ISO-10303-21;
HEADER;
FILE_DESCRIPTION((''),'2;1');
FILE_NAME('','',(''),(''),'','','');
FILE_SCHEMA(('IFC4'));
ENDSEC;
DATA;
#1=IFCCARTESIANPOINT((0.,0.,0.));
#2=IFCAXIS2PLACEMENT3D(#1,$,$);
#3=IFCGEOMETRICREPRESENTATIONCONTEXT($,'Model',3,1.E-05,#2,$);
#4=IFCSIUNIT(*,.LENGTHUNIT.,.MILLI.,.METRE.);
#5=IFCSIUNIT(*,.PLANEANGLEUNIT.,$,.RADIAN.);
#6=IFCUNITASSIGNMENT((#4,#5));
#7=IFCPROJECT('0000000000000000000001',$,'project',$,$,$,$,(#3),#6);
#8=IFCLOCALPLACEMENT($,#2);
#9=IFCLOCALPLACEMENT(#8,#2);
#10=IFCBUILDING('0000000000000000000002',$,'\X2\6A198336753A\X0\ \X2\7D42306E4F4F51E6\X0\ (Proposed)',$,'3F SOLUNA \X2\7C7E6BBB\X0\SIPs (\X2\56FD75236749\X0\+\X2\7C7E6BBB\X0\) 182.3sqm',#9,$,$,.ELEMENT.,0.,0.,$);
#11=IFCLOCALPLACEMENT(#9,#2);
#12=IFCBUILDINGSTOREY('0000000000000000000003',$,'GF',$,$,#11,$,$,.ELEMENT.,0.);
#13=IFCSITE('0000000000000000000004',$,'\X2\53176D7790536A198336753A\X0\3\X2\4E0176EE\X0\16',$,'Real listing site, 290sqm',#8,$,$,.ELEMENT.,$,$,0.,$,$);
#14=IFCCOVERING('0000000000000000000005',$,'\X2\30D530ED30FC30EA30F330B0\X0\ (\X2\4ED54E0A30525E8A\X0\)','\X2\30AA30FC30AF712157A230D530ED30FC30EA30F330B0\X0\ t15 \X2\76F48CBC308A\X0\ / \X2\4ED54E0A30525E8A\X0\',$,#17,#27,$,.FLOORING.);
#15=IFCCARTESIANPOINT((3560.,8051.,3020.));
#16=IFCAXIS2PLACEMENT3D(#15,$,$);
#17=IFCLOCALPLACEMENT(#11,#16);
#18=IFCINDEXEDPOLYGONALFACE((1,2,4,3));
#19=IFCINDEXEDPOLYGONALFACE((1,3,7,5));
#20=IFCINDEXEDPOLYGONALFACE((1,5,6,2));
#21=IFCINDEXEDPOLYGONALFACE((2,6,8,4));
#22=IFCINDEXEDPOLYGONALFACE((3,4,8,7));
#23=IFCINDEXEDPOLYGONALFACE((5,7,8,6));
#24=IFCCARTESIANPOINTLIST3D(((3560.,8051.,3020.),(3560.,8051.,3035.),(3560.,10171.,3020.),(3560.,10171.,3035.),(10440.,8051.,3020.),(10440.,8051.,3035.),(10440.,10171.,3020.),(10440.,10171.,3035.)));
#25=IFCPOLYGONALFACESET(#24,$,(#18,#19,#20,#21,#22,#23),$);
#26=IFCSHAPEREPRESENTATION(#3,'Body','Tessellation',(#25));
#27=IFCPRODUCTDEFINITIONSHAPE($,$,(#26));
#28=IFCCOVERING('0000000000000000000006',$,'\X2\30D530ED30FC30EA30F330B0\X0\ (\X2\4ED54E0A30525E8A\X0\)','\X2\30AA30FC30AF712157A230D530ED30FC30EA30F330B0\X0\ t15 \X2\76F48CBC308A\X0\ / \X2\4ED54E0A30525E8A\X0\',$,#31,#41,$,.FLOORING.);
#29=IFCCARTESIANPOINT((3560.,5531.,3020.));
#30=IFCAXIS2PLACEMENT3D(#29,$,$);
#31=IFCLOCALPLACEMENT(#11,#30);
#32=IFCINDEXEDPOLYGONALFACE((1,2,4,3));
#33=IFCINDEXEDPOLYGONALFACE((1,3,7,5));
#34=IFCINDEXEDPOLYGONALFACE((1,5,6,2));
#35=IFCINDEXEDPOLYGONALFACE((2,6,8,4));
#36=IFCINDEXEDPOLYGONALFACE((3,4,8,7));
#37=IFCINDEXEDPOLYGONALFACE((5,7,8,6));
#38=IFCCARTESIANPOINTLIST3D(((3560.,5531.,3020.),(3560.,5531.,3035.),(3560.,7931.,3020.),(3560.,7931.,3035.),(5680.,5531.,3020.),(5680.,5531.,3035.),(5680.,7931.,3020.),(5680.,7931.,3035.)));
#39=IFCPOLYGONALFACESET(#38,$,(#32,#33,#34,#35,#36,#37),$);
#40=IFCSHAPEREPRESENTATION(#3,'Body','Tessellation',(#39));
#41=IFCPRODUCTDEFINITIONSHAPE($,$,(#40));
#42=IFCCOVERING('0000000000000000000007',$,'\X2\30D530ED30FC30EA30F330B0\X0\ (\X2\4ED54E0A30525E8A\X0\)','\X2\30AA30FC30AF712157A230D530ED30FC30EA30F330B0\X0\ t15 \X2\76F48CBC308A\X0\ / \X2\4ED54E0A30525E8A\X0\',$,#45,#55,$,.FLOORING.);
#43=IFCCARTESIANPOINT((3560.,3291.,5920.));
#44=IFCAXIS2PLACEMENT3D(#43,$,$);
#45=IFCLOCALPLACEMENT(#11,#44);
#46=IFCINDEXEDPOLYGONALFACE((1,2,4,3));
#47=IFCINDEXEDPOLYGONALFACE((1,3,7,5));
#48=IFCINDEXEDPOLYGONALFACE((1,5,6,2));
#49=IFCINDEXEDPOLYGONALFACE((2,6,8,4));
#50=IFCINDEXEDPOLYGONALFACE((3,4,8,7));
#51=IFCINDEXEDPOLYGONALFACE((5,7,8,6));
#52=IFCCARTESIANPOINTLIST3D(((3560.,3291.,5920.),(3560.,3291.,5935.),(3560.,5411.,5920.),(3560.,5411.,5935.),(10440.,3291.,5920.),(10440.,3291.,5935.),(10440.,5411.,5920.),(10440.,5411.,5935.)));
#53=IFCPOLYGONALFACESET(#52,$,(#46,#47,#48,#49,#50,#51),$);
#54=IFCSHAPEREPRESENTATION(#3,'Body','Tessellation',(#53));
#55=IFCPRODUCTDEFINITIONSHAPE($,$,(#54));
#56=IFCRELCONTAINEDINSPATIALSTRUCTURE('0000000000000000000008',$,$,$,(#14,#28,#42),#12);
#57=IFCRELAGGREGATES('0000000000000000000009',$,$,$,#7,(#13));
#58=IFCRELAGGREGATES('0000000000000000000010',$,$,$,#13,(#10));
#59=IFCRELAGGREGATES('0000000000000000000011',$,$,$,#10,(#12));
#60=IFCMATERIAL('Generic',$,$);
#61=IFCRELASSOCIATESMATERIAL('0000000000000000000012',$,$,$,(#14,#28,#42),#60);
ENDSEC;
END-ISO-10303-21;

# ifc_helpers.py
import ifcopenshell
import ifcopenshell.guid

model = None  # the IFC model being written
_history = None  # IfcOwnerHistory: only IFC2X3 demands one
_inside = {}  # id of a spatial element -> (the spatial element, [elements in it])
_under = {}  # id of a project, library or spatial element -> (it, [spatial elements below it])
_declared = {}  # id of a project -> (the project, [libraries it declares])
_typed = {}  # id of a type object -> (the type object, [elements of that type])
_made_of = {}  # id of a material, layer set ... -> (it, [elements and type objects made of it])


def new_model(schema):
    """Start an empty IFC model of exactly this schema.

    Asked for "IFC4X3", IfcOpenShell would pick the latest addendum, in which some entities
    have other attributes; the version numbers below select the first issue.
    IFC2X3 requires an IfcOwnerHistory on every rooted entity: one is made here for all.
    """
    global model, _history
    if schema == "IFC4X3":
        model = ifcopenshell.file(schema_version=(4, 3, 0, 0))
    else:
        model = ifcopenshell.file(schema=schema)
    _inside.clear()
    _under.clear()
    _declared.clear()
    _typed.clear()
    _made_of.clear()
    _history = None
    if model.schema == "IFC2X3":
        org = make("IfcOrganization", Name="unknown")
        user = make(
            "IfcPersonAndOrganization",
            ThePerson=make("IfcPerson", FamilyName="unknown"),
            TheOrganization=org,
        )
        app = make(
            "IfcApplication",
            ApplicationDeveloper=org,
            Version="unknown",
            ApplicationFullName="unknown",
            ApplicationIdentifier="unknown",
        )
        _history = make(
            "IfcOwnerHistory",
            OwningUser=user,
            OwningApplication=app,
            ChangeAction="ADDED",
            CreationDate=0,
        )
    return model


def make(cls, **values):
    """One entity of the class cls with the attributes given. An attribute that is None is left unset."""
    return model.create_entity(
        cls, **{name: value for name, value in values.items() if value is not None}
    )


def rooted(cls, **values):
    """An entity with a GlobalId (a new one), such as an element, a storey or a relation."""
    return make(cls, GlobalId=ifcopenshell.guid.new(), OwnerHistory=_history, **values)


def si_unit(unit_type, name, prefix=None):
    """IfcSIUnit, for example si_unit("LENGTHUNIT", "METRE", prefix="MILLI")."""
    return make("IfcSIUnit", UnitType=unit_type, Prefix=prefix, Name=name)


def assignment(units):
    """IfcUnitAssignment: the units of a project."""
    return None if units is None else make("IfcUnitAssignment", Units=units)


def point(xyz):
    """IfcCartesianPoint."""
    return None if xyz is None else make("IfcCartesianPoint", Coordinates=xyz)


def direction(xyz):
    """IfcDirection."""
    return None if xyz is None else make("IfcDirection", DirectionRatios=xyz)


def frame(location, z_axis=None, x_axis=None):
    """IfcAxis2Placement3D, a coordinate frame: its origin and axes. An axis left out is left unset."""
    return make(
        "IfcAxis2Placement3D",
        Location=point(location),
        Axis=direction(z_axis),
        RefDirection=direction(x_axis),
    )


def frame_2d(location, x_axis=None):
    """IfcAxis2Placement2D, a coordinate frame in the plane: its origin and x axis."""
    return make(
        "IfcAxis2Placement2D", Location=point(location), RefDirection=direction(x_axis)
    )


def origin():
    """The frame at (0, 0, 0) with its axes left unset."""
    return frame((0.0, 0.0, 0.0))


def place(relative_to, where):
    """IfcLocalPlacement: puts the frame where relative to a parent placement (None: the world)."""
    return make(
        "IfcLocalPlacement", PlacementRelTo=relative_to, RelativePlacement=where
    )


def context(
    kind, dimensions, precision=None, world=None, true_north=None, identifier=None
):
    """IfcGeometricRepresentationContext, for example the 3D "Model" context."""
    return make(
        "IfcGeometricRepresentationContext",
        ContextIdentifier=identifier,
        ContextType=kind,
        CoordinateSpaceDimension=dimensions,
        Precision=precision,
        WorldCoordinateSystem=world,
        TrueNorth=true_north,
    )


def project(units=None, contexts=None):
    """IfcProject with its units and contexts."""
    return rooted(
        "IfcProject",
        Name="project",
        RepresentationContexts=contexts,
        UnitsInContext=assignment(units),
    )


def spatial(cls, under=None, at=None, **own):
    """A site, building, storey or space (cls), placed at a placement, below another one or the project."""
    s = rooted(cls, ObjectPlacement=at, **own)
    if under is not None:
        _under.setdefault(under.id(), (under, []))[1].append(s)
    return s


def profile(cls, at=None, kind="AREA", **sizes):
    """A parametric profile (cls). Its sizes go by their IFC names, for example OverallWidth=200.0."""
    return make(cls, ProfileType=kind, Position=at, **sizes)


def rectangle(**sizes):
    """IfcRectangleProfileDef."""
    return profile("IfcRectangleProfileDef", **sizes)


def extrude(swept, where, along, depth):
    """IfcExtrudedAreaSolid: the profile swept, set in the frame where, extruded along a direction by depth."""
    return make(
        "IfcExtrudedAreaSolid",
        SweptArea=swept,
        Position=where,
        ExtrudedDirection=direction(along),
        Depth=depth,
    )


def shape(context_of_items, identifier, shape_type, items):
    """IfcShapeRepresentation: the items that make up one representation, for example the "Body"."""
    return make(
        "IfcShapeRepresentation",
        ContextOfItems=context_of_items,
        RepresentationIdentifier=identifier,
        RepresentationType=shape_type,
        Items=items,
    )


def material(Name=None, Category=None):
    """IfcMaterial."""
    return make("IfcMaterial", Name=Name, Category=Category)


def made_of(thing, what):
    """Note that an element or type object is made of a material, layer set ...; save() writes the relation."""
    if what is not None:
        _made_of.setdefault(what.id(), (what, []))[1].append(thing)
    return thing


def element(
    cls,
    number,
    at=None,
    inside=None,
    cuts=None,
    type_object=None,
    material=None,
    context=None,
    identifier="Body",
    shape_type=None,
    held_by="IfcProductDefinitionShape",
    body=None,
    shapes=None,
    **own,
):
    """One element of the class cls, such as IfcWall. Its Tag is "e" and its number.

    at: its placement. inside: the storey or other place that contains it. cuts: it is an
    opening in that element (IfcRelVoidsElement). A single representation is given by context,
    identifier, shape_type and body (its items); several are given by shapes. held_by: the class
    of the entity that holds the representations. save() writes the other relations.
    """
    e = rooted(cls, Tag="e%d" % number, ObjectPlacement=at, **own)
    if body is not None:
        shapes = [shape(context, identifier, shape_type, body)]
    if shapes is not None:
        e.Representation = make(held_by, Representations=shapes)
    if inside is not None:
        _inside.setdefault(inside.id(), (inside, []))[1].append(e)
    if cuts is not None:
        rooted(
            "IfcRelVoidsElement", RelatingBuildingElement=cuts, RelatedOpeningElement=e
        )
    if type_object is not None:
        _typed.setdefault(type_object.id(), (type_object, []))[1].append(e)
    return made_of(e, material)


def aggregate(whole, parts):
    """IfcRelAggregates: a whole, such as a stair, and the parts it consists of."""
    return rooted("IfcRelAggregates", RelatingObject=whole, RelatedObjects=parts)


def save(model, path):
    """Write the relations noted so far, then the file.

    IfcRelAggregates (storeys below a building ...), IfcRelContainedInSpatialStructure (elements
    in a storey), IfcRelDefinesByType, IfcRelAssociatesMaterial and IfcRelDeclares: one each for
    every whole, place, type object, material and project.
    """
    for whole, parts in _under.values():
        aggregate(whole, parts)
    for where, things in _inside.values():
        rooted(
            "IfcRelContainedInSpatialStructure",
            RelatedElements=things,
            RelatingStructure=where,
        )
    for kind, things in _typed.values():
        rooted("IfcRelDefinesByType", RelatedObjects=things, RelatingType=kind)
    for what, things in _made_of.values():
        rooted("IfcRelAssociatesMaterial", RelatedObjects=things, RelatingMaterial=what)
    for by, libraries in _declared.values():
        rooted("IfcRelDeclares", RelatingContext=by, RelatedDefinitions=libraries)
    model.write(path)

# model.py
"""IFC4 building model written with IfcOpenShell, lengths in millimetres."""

from ifc_helpers import new_model, si_unit, frame, frame_2d, origin, place, context, project, spatial, rectangle, extrude, material, element, save


model = new_model("IFC4")

# Units and contexts
model_context = context("Model", 3, precision=1e-05, world=origin())
ifc_project = project(units=[si_unit("LENGTHUNIT", "METRE", prefix="MILLI"), si_unit("PLANEANGLEUNIT", "RADIAN")], contexts=[model_context])

# Site, building, storey
site_placement = place(None, origin())
site = spatial("IfcSite", under=ifc_project, at=site_placement, Name="北海道標茶町3丁目16", ObjectType="Real listing site, 290sqm", CompositionType="ELEMENT", RefElevation=0.0)
building_placement = place(site_placement, origin())
building = spatial("IfcBuilding", under=site, at=building_placement, Name="標茶町 終の住処 (Proposed)", ObjectType="3F SOLUNA 籾殻SIPs (国産杉+籾殻) 182.3sqm", CompositionType="ELEMENT", ElevationOfRefHeight=0.0, ElevationOfTerrain=0.0)
storey_placement = place(building_placement, origin())
storey = spatial("IfcBuildingStorey", under=building, at=storey_placement, Name="GF", CompositionType="ELEMENT", Elevation=0.0)

# Shared definitions
ifc_material_1 = material(Name="Generic")

# Coverings
covering_1_placement = place(storey_placement, frame((3560.0, 8051.0, 3020.0)))
element("IfcCovering", 1, at=covering_1_placement, inside=storey, material=ifc_material_1, Name="フローリング (仕上げ床)", Description="オーク無垢フローリング t15 直貼り / 仕上げ床", PredefinedType="FLOORING", context=model_context, shape_type="SweptSolid", body=[
    extrude(rectangle(XDim=6880.0, YDim=2120.0, at=frame_2d((3440.0, 1060.0))), frame((3560.0, 8051.0, 3020.0)), (0.0, 0.0, 1.0), 15.0),
])
covering_2_placement = place(storey_placement, frame((3560.0, 5531.0, 3020.0)))
element("IfcCovering", 2, at=covering_2_placement, inside=storey, material=ifc_material_1, Name="フローリング (仕上げ床)", Description="オーク無垢フローリング t15 直貼り / 仕上げ床", PredefinedType="FLOORING", context=model_context, shape_type="SweptSolid", body=[
    extrude(rectangle(XDim=2120.0, YDim=2400.0, at=frame_2d((1060.0, 1200.0))), frame((3560.0, 5531.0, 3020.0)), (0.0, 0.0, 1.0), 15.0),
])
covering_3_placement = place(storey_placement, frame((3560.0, 3291.0, 5920.0)))
element("IfcCovering", 3, at=covering_3_placement, inside=storey, material=ifc_material_1, Name="フローリング (仕上げ床)", Description="オーク無垢フローリング t15 直貼り / 仕上げ床", PredefinedType="FLOORING", context=model_context, shape_type="SweptSolid", body=[
    extrude(rectangle(XDim=6880.0, YDim=2120.0, at=frame_2d((3440.0, 1060.0))), frame((3560.0, 3291.0, 5920.0)), (0.0, 0.0, 1.0), 15.0),
])

save(model, "model.ifc")
